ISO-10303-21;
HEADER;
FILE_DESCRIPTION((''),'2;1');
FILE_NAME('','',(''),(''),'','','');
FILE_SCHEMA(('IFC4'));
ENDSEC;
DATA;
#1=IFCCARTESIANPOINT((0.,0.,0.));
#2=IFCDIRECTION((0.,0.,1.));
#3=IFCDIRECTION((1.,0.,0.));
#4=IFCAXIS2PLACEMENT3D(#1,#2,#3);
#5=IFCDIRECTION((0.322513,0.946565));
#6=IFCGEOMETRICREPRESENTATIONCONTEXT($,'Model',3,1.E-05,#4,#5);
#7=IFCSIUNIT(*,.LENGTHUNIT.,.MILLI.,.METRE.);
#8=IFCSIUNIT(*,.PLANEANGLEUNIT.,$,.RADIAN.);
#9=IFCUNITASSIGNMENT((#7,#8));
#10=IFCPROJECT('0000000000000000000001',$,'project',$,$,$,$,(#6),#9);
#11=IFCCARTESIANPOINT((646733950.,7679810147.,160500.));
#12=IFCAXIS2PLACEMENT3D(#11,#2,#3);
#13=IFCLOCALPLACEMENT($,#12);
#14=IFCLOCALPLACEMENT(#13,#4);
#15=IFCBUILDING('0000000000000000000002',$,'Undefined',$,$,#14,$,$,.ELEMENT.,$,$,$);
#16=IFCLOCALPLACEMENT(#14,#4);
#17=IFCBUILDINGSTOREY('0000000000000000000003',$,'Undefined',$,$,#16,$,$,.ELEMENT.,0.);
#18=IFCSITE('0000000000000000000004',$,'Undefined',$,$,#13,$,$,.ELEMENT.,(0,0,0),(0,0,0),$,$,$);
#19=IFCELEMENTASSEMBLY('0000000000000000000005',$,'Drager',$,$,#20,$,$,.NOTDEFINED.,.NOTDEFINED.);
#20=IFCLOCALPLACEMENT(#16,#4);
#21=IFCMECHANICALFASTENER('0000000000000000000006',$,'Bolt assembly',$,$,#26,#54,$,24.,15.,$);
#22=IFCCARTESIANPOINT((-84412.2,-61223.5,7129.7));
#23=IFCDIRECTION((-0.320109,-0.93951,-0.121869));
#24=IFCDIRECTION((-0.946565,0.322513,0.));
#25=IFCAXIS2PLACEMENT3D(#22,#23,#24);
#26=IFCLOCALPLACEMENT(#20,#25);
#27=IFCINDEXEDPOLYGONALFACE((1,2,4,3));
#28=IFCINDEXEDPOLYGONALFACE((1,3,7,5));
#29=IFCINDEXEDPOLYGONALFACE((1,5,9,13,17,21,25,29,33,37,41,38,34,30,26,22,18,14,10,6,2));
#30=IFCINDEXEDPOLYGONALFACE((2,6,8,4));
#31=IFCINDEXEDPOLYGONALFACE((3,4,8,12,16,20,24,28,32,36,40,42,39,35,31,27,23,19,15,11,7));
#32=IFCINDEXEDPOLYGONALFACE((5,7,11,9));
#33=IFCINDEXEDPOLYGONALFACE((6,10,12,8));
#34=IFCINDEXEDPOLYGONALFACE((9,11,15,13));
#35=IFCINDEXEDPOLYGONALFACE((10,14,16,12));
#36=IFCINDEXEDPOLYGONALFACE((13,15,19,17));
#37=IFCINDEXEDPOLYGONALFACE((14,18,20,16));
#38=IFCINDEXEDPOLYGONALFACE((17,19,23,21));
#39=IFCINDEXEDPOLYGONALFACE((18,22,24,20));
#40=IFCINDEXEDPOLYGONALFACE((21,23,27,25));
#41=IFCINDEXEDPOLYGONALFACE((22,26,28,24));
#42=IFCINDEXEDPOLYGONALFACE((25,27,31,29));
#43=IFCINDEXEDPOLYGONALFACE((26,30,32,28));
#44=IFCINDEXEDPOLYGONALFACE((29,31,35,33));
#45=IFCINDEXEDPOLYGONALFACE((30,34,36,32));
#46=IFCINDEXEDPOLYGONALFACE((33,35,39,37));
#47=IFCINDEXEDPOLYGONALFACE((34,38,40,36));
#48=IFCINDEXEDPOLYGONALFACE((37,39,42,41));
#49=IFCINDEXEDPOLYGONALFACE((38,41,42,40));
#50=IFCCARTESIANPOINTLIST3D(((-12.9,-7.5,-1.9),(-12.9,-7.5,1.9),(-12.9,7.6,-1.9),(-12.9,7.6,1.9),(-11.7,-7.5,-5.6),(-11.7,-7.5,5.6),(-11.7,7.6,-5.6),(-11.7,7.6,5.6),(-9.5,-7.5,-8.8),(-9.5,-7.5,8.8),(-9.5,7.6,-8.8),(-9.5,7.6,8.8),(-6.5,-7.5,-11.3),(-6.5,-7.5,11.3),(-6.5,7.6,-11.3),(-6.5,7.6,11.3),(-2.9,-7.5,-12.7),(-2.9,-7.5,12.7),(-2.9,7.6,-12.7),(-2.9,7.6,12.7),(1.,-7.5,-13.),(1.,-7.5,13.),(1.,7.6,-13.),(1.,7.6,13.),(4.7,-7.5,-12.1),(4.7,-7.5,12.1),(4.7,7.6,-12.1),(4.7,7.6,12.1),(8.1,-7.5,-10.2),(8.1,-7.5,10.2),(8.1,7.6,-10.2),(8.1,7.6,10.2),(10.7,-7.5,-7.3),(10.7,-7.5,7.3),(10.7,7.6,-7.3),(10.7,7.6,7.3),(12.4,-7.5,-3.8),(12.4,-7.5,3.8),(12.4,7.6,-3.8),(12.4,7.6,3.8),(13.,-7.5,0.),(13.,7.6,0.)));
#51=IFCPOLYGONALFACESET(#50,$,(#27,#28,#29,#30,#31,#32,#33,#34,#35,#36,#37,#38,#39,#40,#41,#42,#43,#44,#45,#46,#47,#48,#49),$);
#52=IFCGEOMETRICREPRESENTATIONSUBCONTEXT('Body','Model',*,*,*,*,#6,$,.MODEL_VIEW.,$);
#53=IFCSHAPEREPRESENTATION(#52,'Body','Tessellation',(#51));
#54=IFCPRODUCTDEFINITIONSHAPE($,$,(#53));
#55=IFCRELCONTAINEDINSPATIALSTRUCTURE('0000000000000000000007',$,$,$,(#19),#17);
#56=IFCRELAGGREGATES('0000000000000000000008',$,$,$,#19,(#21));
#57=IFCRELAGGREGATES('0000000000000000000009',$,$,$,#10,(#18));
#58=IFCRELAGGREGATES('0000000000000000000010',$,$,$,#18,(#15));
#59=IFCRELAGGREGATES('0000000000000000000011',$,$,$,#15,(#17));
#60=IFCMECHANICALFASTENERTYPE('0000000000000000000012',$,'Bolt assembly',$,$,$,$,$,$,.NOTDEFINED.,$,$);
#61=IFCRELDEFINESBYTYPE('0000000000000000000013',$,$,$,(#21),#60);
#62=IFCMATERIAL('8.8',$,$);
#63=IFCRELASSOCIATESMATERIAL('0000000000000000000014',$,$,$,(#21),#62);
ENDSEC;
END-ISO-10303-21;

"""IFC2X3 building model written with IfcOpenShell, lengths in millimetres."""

from ifc_helpers import new_model, si_unit, direction, frame, origin_with_axes, origin_2d_with_axis, place, context, subcontext, project, spatial, circle, extrude, source, transform, mapped, material, type_object, element, aggregate, save


model = new_model("IFC2X3")

# Units and contexts
model_context = context("Model", 3, precision=1e-05, world=origin_with_axes(), true_north=direction((0.322513, 0.946565)))
body_context = subcontext(model_context, "Body", "Model", "MODEL_VIEW")
ifc_project = project(units=[si_unit("LENGTHUNIT", "METRE", prefix="MILLI"), si_unit("PLANEANGLEUNIT", "RADIAN")], contexts=[model_context])

# Site, building, storey
site_placement = place(None, frame((646733950.0, 7679810147.0, 160500.0), z_axis=(0.0, 0.0, 1.0), x_axis=(1.0, 0.0, 0.0)))
site = spatial("IfcSite", under=ifc_project, at=site_placement, Name="Undefined", CompositionType="ELEMENT", RefLatitude=(0, 0, 0), RefLongitude=(0, 0, 0))
building_placement = place(site_placement, origin_with_axes())
building = spatial("IfcBuilding", under=site, at=building_placement, Name="Undefined", CompositionType="ELEMENT")
storey_placement = place(building_placement, origin_with_axes())
storey = spatial("IfcBuildingStorey", under=building, at=storey_placement, Name="Undefined", CompositionType="ELEMENT", Elevation=0.0)

# Element assembly
assembly_1_placement = place(storey_placement, origin_with_axes())
assembly_1 = element("IfcElementAssembly", 1, at=assembly_1_placement, inside=storey, Name="Drager", AssemblyPlace="NOTDEFINED", PredefinedType="NOTDEFINED")

# Mechanical fastener
ifc_material_1 = material(Name="8.8")
mechanical_fastener_type = type_object("IfcMechanicalFastenerType", Name="Bolt assembly")
shared_shape_1 = source(origin_with_axes(), body_context, "Body", "SweptSolid", [
    extrude(circle(Radius=13.0, at=origin_2d_with_axis()), frame((0.0, -7.5, 0.0), z_axis=(0.0, 1.0, 0.0), x_axis=(1.0, 0.0, 0.0)), (0.0, 0.0, 1.0), 15.1),
])
mechanical_fastener_1_placement = place(assembly_1_placement, frame((-84412.2, -61223.5, 7129.7), z_axis=(-0.320109, -0.93951, -0.121869), x_axis=(-0.946565, 0.322513, 0.0)))
mechanical_fastener_1 = element("IfcMechanicalFastener", 2, at=mechanical_fastener_1_placement, type_object=mechanical_fastener_type, material=ifc_material_1, Name="Bolt assembly", NominalDiameter=24.0, NominalLength=15.0, context=body_context, shape_type="MappedRepresentation", body=[
    mapped(shared_shape_1, transform((0.0, 0.0, 0.0))),
])
aggregate(assembly_1, [mechanical_fastener_1])

save(model, "model.ifc")
